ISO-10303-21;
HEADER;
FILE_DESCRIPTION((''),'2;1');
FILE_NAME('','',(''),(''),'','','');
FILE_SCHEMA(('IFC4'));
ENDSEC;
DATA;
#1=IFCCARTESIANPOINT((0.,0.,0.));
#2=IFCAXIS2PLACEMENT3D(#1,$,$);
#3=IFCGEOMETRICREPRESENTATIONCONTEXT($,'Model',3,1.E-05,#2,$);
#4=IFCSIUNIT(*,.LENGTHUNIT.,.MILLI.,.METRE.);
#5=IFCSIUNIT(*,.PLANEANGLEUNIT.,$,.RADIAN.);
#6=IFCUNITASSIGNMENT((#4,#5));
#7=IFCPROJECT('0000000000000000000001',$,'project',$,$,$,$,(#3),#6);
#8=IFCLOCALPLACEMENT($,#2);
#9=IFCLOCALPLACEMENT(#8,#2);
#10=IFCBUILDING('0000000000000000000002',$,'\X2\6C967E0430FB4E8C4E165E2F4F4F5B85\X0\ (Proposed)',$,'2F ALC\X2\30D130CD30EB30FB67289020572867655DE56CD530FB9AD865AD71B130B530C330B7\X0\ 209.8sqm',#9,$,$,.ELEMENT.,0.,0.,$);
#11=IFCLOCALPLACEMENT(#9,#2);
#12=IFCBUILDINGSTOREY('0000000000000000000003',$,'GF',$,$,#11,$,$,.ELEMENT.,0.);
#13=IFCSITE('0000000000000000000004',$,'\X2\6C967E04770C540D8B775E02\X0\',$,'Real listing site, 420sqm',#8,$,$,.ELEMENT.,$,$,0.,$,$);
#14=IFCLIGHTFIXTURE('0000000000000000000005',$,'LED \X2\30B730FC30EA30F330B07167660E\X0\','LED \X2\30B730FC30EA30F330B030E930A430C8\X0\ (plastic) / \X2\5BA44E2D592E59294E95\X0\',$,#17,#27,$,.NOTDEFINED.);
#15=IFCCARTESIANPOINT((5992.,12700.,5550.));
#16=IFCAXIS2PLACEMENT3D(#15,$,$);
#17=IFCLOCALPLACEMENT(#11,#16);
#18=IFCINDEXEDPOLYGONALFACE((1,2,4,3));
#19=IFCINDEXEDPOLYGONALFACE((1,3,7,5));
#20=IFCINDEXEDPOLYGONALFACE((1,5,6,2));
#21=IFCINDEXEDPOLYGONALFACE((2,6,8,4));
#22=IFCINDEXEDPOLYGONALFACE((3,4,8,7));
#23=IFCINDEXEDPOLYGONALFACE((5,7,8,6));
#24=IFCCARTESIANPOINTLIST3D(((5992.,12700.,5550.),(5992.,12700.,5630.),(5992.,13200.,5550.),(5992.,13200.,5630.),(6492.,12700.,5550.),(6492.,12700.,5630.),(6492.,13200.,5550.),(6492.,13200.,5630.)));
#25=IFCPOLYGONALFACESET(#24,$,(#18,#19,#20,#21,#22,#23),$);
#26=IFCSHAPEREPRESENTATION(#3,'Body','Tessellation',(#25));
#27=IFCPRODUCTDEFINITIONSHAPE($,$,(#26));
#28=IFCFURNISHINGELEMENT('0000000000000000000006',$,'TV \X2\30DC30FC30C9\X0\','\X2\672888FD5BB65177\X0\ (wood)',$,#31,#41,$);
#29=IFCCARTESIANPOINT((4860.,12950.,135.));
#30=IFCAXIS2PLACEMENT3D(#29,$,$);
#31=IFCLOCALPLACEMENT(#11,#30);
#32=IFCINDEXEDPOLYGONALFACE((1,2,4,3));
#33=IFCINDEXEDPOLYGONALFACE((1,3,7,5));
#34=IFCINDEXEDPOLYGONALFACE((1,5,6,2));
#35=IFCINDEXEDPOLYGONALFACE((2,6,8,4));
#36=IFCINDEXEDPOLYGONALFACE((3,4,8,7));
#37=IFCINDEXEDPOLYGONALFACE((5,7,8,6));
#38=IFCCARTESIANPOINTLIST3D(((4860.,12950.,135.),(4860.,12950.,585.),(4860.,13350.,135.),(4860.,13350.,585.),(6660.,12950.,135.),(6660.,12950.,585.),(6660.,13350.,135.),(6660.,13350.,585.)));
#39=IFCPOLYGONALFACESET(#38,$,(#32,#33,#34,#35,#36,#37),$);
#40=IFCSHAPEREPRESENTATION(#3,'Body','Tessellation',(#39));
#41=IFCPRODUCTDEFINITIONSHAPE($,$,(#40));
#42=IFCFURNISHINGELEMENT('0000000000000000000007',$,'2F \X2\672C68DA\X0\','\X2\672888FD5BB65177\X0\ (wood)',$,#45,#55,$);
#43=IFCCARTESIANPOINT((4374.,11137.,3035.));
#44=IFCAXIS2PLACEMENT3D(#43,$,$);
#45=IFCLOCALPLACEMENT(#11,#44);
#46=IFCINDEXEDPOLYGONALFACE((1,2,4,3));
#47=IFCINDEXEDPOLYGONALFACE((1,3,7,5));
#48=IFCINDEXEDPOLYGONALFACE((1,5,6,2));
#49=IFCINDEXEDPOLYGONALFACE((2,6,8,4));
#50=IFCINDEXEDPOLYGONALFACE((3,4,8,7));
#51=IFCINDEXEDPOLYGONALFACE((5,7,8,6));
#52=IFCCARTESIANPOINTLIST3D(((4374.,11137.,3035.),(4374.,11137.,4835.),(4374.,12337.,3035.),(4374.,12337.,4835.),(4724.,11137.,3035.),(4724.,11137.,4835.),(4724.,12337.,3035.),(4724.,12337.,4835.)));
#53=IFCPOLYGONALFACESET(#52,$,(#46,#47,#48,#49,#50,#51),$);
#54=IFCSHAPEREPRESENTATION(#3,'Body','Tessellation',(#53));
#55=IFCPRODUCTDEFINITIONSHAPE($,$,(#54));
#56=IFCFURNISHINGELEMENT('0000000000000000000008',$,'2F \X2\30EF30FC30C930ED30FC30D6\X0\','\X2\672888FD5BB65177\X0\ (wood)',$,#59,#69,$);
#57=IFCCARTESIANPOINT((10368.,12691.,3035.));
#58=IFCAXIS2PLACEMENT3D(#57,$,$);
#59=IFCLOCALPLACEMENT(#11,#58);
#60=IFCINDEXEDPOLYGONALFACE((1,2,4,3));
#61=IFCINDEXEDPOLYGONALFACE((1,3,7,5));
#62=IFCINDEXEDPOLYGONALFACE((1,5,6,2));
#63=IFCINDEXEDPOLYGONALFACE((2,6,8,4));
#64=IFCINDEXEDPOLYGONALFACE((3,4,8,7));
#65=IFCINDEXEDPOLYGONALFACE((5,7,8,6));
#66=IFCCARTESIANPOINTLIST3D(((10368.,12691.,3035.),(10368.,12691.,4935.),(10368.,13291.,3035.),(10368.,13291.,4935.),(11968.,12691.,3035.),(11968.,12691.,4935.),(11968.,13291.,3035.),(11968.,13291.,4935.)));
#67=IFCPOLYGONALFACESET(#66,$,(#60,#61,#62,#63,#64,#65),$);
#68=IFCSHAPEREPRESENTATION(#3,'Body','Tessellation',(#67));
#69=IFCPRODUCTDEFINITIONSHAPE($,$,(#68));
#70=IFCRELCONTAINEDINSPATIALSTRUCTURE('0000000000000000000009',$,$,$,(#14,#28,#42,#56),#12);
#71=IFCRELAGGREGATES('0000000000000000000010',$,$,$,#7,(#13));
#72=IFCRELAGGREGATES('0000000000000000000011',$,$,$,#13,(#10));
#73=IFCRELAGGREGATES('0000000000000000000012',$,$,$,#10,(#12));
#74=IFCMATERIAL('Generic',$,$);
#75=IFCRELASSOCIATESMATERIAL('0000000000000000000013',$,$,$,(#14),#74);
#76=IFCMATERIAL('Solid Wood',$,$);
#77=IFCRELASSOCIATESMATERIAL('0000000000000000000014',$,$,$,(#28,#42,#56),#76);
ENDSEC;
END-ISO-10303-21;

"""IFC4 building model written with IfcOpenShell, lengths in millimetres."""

from ifc_helpers import new_model, si_unit, frame, frame_2d, origin, place, context, project, spatial, rectangle, extrude, material, element, save


model = new_model("IFC4")

# Units and contexts
model_context = context("Model", 3, precision=1e-05, world=origin())
ifc_project = project(units=[si_unit("LENGTHUNIT", "METRE", prefix="MILLI"), si_unit("PLANEANGLEUNIT", "RADIAN")], contexts=[model_context])

# Site, building, storey
site_placement = place(None, origin())
site = spatial("IfcSite", under=ifc_project, at=site_placement, Name="沖縄県名護市", ObjectType="Real listing site, 420sqm", CompositionType="ELEMENT", RefElevation=0.0)
building_placement = place(site_placement, origin())
building = spatial("IfcBuilding", under=site, at=building_placement, Name="沖縄・二世帯住宅 (Proposed)", ObjectType="2F ALCパネル・木造在来工法・高断熱サッシ 209.8sqm", CompositionType="ELEMENT", ElevationOfRefHeight=0.0, ElevationOfTerrain=0.0)
storey_placement = place(building_placement, origin())
storey = spatial("IfcBuildingStorey", under=building, at=storey_placement, Name="GF", CompositionType="ELEMENT", Elevation=0.0)

# Shared definitions
ifc_material_1 = material(Name="Solid Wood")

# Shared definitions
ifc_material_2 = material(Name="Generic")

# Light fixture
light_fixture_1_placement = place(storey_placement, frame((5992.0, 12700.0, 5550.0)))
element("IfcLightFixture", 1, at=light_fixture_1_placement, inside=storey, material=ifc_material_2, Name="LED シーリング照明", Description="LED シーリングライト (plastic) / 室中央天井", PredefinedType="NOTDEFINED", context=model_context, shape_type="SweptSolid", body=[
    extrude(rectangle(XDim=500.0, YDim=500.0, at=frame_2d((250.0, 250.0))), frame((5992.0, 12700.0, 5550.0)), (0.0, 0.0, 1.0), 80.0),
])

# Furnishing elements
furnishing_1_placement = place(storey_placement, frame((4860.0, 12950.0, 135.0)))
element("IfcFurnishingElement", 2, at=furnishing_1_placement, inside=storey, material=ifc_material_1, Name="TV ボード", Description="木製家具 (wood)", context=model_context, shape_type="SweptSolid", body=[
    extrude(rectangle(XDim=1800.0, YDim=400.0, at=frame_2d((900.0, 200.0))), frame((4860.0, 12950.0, 135.0)), (0.0, 0.0, 1.0), 450.0),
])
furnishing_2_placement = place(storey_placement, frame((4374.0, 11137.0, 3035.0)))
element("IfcFurnishingElement", 3, at=furnishing_2_placement, inside=storey, material=ifc_material_1, Name="2F 本棚", Description="木製家具 (wood)", context=model_context, shape_type="SweptSolid", body=[
    extrude(rectangle(XDim=350.0, YDim=1200.0, at=frame_2d((175.0, 600.0))), frame((4374.0, 11137.0, 3035.0)), (0.0, 0.0, 1.0), 1800.0),
])
furnishing_3_placement = place(storey_placement, frame((10368.0, 12691.0, 3035.0)))
element("IfcFurnishingElement", 4, at=furnishing_3_placement, inside=storey, material=ifc_material_1, Name="2F ワードローブ", Description="木製家具 (wood)", context=model_context, shape_type="SweptSolid", body=[
    extrude(rectangle(XDim=1600.0, YDim=600.0, at=frame_2d((800.0, 300.0))), frame((10368.0, 12691.0, 3035.0)), (0.0, 0.0, 1.0), 1900.0),
])

save(model, "model.ifc")
